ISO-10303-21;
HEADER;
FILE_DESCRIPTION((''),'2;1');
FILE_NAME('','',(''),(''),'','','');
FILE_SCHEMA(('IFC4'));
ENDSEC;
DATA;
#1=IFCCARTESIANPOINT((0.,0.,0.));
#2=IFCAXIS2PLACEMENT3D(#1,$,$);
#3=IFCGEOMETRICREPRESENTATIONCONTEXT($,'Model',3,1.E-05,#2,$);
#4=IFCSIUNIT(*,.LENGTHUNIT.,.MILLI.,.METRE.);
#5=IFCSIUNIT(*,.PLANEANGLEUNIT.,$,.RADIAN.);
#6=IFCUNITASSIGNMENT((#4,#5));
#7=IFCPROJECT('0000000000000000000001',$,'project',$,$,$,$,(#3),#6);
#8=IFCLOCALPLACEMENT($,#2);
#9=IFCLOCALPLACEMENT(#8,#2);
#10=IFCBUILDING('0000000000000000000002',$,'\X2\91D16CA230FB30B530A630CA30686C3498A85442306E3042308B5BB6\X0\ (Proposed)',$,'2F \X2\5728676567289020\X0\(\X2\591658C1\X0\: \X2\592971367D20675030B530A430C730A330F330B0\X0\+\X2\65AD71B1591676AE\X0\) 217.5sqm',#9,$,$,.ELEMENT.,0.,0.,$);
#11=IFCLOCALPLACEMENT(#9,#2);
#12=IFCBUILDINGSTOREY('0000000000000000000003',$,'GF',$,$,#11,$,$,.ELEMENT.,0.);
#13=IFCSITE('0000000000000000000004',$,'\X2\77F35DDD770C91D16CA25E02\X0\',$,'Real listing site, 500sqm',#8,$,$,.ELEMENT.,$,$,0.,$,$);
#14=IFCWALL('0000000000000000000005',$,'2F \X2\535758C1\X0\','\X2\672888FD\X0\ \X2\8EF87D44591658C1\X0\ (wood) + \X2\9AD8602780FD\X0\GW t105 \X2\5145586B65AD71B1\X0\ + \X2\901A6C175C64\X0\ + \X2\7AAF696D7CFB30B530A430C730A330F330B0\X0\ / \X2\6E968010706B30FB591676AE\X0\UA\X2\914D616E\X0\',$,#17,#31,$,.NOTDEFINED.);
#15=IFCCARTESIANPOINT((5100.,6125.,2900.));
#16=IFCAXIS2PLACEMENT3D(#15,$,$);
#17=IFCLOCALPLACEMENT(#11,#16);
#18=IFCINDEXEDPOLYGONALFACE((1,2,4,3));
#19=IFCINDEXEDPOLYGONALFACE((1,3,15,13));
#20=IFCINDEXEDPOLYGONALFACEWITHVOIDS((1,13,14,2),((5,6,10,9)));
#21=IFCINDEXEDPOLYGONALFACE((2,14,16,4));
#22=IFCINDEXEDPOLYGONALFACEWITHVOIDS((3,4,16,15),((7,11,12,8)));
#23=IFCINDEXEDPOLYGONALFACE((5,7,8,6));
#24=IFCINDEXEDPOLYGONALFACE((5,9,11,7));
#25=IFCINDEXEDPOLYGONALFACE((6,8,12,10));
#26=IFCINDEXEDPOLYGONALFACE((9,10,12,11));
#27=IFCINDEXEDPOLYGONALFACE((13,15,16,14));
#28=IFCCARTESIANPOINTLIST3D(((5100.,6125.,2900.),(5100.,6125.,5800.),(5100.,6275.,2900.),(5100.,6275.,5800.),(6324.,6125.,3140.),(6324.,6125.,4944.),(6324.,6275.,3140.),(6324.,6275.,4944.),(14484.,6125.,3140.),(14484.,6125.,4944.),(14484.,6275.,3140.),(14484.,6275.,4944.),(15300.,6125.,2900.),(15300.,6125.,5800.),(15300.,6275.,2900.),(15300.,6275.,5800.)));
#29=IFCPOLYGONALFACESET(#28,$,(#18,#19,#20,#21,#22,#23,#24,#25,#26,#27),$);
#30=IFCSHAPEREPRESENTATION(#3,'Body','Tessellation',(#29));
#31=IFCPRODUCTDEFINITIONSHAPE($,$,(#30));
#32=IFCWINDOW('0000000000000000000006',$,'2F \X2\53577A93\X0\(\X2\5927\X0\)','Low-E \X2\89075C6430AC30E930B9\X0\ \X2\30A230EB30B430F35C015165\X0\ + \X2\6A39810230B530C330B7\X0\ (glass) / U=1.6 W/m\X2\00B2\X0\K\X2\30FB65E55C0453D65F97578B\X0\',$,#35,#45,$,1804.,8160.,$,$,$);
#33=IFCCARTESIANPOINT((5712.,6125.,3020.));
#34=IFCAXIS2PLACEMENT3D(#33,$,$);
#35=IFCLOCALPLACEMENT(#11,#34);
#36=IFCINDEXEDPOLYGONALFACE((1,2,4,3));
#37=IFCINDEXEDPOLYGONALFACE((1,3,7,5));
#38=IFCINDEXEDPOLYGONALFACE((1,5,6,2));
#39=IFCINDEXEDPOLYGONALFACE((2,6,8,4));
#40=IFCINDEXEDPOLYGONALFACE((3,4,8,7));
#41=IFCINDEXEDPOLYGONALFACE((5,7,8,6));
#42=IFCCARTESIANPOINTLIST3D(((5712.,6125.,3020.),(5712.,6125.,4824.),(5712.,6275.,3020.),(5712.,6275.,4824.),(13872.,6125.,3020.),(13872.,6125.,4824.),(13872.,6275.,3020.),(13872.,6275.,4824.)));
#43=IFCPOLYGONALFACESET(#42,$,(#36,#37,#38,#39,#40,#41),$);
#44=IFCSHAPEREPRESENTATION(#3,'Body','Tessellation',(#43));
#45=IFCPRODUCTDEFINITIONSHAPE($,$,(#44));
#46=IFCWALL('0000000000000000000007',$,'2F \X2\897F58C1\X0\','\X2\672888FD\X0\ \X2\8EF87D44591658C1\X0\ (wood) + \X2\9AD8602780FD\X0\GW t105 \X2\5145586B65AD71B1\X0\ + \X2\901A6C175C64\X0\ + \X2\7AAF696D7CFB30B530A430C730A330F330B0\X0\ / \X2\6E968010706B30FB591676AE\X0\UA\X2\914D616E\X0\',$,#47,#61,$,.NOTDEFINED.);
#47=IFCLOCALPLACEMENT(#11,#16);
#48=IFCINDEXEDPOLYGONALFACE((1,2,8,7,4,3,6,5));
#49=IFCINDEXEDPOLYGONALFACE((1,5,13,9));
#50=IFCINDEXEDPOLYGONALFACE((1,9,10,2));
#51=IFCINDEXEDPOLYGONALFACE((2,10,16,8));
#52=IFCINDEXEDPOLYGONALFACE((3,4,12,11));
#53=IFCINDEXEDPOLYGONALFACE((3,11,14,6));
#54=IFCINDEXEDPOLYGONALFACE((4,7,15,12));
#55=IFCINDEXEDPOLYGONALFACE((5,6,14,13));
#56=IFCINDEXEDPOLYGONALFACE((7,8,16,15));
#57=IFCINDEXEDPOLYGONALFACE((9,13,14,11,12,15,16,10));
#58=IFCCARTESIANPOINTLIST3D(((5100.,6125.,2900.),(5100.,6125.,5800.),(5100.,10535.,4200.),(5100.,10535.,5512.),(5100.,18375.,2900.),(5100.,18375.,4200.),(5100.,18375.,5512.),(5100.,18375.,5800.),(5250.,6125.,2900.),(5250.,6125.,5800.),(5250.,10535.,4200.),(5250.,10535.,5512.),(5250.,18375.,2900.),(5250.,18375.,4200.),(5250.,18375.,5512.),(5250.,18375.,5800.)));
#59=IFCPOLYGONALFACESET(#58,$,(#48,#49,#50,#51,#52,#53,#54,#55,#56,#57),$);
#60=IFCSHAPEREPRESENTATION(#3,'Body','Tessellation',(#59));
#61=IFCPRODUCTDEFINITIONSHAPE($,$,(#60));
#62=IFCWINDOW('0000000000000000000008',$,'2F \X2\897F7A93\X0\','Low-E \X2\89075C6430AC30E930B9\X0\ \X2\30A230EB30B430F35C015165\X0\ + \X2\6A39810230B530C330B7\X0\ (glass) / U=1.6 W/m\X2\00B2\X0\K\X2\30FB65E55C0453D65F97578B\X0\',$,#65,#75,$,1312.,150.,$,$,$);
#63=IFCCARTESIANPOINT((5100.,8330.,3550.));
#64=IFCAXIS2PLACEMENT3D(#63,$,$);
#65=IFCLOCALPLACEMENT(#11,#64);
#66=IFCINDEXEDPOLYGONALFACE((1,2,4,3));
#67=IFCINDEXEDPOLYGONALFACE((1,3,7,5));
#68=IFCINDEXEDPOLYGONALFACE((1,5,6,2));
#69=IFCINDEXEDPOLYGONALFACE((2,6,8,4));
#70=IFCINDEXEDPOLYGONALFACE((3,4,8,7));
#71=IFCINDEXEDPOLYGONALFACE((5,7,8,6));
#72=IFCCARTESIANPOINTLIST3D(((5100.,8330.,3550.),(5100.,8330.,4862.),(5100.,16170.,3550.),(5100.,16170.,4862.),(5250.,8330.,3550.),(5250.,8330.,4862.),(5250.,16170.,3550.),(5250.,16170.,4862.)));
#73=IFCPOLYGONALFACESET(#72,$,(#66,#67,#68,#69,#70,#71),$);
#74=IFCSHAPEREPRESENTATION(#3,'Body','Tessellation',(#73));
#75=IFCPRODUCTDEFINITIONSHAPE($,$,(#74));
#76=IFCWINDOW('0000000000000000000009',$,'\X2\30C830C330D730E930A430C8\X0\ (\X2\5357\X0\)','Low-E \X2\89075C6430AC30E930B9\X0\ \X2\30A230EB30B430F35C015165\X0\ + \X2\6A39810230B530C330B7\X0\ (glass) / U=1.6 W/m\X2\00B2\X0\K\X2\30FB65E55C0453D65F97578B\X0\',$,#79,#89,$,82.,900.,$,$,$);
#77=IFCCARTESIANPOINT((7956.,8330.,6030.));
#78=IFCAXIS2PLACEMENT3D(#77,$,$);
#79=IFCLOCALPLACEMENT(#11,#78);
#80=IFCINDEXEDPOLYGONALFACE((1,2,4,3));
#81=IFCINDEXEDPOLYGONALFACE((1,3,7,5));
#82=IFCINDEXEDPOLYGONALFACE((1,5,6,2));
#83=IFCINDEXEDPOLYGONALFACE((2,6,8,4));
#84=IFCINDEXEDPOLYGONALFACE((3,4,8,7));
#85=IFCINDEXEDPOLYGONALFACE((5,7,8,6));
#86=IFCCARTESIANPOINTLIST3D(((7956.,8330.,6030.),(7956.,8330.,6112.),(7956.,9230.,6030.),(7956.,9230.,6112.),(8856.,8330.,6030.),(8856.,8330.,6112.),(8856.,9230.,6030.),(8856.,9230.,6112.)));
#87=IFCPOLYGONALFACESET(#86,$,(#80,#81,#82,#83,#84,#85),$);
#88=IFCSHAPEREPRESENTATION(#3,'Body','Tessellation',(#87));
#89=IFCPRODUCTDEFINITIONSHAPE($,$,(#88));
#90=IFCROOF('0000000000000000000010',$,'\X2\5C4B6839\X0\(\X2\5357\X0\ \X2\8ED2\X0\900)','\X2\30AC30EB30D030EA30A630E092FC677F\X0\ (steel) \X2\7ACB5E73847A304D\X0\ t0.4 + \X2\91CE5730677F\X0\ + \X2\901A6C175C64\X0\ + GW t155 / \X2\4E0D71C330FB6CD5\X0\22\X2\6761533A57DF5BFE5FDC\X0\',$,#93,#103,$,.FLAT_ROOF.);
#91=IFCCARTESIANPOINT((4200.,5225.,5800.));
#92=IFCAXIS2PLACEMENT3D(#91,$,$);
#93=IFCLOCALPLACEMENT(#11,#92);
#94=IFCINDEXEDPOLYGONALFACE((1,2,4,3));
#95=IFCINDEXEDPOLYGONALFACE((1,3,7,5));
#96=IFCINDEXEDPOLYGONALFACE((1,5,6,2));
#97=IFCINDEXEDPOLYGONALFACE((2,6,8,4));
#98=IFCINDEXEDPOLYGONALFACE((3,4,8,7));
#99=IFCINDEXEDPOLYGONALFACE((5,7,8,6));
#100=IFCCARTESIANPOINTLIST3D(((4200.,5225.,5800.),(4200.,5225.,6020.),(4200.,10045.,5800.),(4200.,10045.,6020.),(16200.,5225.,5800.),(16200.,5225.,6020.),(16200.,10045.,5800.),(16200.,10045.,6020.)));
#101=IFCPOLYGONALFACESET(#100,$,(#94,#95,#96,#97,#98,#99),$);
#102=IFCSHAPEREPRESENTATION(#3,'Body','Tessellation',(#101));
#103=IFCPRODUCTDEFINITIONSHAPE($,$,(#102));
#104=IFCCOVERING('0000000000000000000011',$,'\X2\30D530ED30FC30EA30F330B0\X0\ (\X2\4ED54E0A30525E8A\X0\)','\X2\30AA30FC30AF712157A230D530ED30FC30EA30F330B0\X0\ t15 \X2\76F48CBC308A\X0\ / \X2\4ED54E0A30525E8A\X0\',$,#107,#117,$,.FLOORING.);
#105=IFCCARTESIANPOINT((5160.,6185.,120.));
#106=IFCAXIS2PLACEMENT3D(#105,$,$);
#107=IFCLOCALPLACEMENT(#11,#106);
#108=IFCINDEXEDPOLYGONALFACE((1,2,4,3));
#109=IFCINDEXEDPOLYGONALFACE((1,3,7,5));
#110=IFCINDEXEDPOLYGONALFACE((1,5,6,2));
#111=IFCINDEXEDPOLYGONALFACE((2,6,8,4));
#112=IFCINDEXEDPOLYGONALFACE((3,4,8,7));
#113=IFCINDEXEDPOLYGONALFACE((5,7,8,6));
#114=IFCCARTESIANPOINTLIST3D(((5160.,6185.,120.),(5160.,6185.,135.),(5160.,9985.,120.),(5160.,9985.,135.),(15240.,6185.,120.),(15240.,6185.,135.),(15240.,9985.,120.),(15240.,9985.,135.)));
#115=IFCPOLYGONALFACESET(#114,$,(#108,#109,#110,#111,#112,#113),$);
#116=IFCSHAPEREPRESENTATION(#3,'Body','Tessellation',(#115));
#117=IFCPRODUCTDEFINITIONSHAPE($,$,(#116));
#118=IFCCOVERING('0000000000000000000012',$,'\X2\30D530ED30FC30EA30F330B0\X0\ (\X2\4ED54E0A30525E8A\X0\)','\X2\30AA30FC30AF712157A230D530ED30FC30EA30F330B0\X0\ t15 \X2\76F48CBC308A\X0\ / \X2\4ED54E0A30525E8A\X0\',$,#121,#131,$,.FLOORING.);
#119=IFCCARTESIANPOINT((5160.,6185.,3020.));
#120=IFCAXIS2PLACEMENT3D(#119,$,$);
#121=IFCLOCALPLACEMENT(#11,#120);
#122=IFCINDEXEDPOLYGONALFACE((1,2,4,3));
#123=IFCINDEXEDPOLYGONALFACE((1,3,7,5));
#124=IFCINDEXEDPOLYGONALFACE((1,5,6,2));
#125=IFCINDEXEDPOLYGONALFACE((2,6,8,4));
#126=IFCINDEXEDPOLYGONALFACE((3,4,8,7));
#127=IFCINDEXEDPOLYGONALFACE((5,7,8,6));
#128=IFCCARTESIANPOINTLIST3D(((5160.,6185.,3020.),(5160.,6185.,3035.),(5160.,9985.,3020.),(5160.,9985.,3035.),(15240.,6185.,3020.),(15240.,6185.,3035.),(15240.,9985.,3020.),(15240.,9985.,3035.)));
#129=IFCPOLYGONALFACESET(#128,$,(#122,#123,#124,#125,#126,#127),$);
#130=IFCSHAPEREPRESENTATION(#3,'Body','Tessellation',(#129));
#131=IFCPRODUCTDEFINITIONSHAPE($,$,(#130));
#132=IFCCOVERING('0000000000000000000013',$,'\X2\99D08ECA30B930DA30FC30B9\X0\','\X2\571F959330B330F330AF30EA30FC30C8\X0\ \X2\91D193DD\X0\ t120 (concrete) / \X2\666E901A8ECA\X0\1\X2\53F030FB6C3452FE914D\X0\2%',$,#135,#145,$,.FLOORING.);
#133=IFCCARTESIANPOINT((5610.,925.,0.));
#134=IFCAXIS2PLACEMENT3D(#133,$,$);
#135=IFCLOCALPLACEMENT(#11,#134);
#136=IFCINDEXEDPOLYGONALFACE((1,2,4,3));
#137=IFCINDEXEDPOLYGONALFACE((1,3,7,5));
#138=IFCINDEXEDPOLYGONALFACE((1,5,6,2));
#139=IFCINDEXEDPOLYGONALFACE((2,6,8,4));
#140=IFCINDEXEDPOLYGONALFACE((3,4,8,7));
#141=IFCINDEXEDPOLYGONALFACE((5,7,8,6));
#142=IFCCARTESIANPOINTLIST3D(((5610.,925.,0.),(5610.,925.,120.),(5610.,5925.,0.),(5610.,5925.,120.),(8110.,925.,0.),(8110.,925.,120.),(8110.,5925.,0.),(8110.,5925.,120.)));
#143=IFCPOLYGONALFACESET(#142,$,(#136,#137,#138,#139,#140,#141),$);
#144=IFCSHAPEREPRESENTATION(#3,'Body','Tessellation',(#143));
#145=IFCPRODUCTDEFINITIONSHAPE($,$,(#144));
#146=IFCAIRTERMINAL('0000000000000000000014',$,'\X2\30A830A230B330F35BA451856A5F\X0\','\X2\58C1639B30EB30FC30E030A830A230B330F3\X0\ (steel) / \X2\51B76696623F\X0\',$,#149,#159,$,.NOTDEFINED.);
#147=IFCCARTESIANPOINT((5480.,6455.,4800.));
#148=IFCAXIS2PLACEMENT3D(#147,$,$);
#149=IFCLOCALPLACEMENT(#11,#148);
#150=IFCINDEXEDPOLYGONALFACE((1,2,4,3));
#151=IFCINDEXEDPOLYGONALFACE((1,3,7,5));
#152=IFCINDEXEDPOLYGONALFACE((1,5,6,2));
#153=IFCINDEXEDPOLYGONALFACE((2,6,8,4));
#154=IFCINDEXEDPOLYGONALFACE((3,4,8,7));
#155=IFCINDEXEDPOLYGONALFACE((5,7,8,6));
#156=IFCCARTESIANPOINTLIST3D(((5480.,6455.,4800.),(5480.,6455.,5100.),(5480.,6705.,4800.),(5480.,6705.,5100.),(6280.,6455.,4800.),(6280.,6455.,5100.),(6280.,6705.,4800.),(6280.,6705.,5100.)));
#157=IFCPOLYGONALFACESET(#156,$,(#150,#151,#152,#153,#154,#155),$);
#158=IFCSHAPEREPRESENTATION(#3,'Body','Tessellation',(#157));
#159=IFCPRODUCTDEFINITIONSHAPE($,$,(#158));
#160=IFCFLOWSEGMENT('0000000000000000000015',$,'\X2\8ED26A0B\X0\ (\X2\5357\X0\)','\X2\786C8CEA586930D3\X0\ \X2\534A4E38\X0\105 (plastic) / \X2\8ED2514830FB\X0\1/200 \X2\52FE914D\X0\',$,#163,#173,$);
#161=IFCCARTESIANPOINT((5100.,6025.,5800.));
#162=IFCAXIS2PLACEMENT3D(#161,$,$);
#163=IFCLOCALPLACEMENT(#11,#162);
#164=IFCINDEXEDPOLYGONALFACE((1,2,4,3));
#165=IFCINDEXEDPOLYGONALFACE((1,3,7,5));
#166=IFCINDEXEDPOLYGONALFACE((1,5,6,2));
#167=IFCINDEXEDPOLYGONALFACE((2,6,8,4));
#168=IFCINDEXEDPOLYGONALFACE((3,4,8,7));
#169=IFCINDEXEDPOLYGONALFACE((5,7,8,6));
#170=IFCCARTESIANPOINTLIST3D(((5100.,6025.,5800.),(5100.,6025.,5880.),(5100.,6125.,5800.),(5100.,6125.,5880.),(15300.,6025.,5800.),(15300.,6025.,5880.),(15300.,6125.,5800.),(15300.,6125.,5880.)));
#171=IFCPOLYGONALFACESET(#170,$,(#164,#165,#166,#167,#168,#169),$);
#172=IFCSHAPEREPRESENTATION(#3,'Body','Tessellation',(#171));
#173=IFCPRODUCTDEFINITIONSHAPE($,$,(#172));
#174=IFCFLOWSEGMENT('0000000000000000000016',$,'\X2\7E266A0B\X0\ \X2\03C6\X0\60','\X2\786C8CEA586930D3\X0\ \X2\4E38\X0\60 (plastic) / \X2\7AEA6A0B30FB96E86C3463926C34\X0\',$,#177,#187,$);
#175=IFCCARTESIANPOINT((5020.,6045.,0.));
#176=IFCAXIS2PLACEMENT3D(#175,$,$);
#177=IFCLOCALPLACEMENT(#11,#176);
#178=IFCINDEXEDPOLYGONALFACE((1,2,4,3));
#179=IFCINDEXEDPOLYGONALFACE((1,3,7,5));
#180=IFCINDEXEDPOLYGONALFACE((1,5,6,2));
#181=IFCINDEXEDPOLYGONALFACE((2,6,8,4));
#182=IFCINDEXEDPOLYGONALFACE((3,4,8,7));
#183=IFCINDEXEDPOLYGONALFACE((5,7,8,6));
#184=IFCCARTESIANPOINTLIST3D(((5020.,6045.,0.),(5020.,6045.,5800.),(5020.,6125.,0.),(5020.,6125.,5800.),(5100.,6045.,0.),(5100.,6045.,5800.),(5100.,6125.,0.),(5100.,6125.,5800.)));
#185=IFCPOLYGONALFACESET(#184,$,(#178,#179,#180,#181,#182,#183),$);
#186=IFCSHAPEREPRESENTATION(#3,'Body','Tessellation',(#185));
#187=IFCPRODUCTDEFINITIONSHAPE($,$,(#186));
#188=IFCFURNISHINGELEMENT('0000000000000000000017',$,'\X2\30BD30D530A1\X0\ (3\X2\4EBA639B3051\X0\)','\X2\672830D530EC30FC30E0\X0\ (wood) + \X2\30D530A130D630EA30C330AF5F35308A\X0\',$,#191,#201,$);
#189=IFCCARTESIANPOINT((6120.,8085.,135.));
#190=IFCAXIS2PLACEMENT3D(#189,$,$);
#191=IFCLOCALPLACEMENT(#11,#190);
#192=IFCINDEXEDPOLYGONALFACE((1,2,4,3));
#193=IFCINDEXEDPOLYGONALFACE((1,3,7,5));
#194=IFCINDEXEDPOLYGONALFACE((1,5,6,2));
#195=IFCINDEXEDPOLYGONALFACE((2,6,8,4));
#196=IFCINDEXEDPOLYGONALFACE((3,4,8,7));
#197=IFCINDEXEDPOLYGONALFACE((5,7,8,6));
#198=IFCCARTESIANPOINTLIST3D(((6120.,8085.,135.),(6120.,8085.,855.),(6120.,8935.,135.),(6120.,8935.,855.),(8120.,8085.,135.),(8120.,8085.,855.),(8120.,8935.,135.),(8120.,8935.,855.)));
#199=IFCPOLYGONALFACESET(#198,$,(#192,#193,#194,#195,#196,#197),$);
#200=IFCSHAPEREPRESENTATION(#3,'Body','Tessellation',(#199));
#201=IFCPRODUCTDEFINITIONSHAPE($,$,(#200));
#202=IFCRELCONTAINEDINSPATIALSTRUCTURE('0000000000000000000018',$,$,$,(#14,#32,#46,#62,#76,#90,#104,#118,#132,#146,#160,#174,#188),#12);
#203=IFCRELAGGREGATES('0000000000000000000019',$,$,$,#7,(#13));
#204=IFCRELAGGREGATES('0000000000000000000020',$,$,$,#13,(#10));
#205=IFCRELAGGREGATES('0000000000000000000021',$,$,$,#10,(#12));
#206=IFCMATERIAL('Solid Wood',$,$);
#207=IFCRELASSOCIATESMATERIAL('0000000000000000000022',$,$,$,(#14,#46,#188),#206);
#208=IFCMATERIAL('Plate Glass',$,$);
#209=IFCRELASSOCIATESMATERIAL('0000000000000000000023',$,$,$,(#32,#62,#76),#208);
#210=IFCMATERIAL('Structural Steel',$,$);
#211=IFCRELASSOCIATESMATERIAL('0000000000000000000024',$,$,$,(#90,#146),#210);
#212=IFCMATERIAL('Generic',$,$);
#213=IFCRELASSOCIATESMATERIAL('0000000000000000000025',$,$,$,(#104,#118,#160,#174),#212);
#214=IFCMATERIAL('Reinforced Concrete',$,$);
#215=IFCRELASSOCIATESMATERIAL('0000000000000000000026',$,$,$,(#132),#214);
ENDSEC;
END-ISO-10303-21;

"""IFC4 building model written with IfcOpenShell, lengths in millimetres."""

from ifc_helpers import new_model, si_unit, frame, frame_2d, origin, place, context, project, spatial, rectangle, extrude, material, element, fill, save


model = new_model("IFC4")

# Units and contexts
model_context = context("Model", 3, precision=1e-05, world=origin())
ifc_project = project(units=[si_unit("LENGTHUNIT", "METRE", prefix="MILLI"), si_unit("PLANEANGLEUNIT", "RADIAN")], contexts=[model_context])

# Site, building, storey
site_placement = place(None, origin())
site = spatial("IfcSite", under=ifc_project, at=site_placement, Name="石川県金沢市", ObjectType="Real listing site, 500sqm", CompositionType="ELEMENT", RefElevation=0.0)
building_placement = place(site_placement, origin())
building = spatial("IfcBuilding", under=site, at=building_placement, Name="金沢・サウナと水風呂のある家 (Proposed)", ObjectType="2F 在来木造(外壁: 天然素材サイディング+断熱外皮) 217.5sqm", CompositionType="ELEMENT", ElevationOfRefHeight=0.0, ElevationOfTerrain=0.0)
storey_placement = place(building_placement, origin())
storey = spatial("IfcBuildingStorey", under=building, at=storey_placement, Name="GF", CompositionType="ELEMENT", Elevation=0.0)

# Shared definitions
ifc_material_1 = material(Name="Solid Wood")

# Shared definitions
ifc_material_2 = material(Name="Reinforced Concrete")

# Shared definitions
ifc_material_3 = material(Name="Plate Glass")

# Walls, openings, windows
wall_1_placement = place(storey_placement, frame((5100.0, 6125.0, 2900.0)))
wall_1 = element("IfcWall", 1, at=wall_1_placement, inside=storey, material=ifc_material_1, Name="2F 南壁", Description="木製 軸組外壁 (wood) + 高性能GW t105 充填断熱 + 通気層 + 窯業系サイディング / 準耐火・外皮UA配慮", PredefinedType="NOTDEFINED", context=model_context, shape_type="SweptSolid", body=[
    extrude(rectangle(XDim=10200.0, YDim=150.0, at=frame_2d((5100.0, 75.0))), frame((5100.0, 6125.0, 2900.0)), (0.0, 0.0, 1.0), 2900.0),
])
opening_1_placement = place(storey_placement, frame((5712.0, 6125.0, 3020.0)))
opening_1 = element("IfcOpeningElement", 2, at=opening_1_placement, cuts=wall_1, PredefinedType="NOTDEFINED", context=model_context, shape_type="SweptSolid", body=[
    extrude(rectangle(XDim=8160.0, YDim=150.0, at=frame_2d((4080.0, 75.0))), frame((5712.0, 6125.0, 3020.0)), (0.0, 0.0, 1.0), 1804.0),
])
window_1_placement = place(storey_placement, frame((5712.0, 6125.0, 3020.0)))
window_1 = element("IfcWindow", 3, at=window_1_placement, inside=storey, material=ifc_material_3, Name="2F 南窓(大)", Description="Low-E 複層ガラス アルゴン封入 + 樹脂サッシ (glass) / U=1.6 W/m²K・日射取得型", OverallHeight=1804.0, OverallWidth=8160.0, context=model_context, shape_type="SweptSolid", body=[
    extrude(rectangle(XDim=8160.0, YDim=150.0, at=frame_2d((4080.0, 75.0))), frame((5712.0, 6125.0, 3020.0)), (0.0, 0.0, 1.0), 1804.0),
])
fill(opening_1, window_1)
wall_2_placement = place(storey_placement, frame((5100.0, 6125.0, 2900.0)))
wall_2 = element("IfcWall", 4, at=wall_2_placement, inside=storey, material=ifc_material_1, Name="2F 西壁", Description="木製 軸組外壁 (wood) + 高性能GW t105 充填断熱 + 通気層 + 窯業系サイディング / 準耐火・外皮UA配慮", PredefinedType="NOTDEFINED", context=model_context, shape_type="SweptSolid", body=[
    extrude(rectangle(XDim=150.0, YDim=12250.0, at=frame_2d((75.0, 6125.0))), frame((5100.0, 6125.0, 2900.0)), (0.0, 0.0, 1.0), 2900.0),
])
opening_2_placement = place(storey_placement, frame((5100.0, 8330.0, 3550.0)))
opening_2 = element("IfcOpeningElement", 5, at=opening_2_placement, cuts=wall_2, PredefinedType="NOTDEFINED", context=model_context, shape_type="SweptSolid", body=[
    extrude(rectangle(XDim=150.0, YDim=7840.0, at=frame_2d((75.0, 3920.0))), frame((5100.0, 8330.0, 3550.0)), (0.0, 0.0, 1.0), 1312.0),
])
window_2_placement = place(storey_placement, frame((5100.0, 8330.0, 3550.0)))
window_2 = element("IfcWindow", 6, at=window_2_placement, inside=storey, material=ifc_material_3, Name="2F 西窓", Description="Low-E 複層ガラス アルゴン封入 + 樹脂サッシ (glass) / U=1.6 W/m²K・日射取得型", OverallHeight=1312.0, OverallWidth=150.0, context=model_context, shape_type="SweptSolid", body=[
    extrude(rectangle(XDim=150.0, YDim=7840.0, at=frame_2d((75.0, 3920.0))), frame((5100.0, 8330.0, 3550.0)), (0.0, 0.0, 1.0), 1312.0),
])
fill(opening_2, window_2)

# Window
window_3_placement = place(storey_placement, frame((7956.0, 8330.0, 6030.0)))
element("IfcWindow", 7, at=window_3_placement, inside=storey, material=ifc_material_3, Name="トップライト (南)", Description="Low-E 複層ガラス アルゴン封入 + 樹脂サッシ (glass) / U=1.6 W/m²K・日射取得型", OverallHeight=82.0, OverallWidth=900.0, context=model_context, shape_type="SweptSolid", body=[
    extrude(rectangle(XDim=900.0, YDim=900.0, at=frame_2d((450.0, 450.0))), frame((7956.0, 8330.0, 6030.0)), (0.0, 0.0, 1.0), 82.0),
])

# Roof
ifc_material_4 = material(Name="Structural Steel")
for number, where, name in (
    (8, (4200.0, 5225.0, 5800.0), "屋根(南 軒900)"),
):
    element("IfcRoof", number, at=place(storey_placement, frame(where)), inside=storey, material=ifc_material_4, Name=name, Description="ガルバリウム鋼板 (steel) 立平葺き t0.4 + 野地板 + 通気層 + GW t155 / 不燃・法22条区域対応", PredefinedType="FLAT_ROOF", context=model_context, shape_type="SweptSolid", body=[
        extrude(rectangle(XDim=12000.0, YDim=4820.0, at=frame_2d((6000.0, 2410.0))), frame((4200.0, 5225.0, 5800.0)), (0.0, 0.0, 1.0), 220.0),
    ])

# Coverings
ifc_material_5 = material(Name="Generic")
covering_1_placement = place(storey_placement, frame((5160.0, 6185.0, 120.0)))
element("IfcCovering", 9, at=covering_1_placement, inside=storey, material=ifc_material_5, Name="フローリング (仕上げ床)", Description="オーク無垢フローリング t15 直貼り / 仕上げ床", PredefinedType="FLOORING", context=model_context, shape_type="SweptSolid", body=[
    extrude(rectangle(XDim=10080.0, YDim=3800.0, at=frame_2d((5040.0, 1900.0))), frame((5160.0, 6185.0, 120.0)), (0.0, 0.0, 1.0), 15.0),
])
covering_2_placement = place(storey_placement, frame((5160.0, 6185.0, 3020.0)))
element("IfcCovering", 10, at=covering_2_placement, inside=storey, material=ifc_material_5, Name="フローリング (仕上げ床)", Description="オーク無垢フローリング t15 直貼り / 仕上げ床", PredefinedType="FLOORING", context=model_context, shape_type="SweptSolid", body=[
    extrude(rectangle(XDim=10080.0, YDim=3800.0, at=frame_2d((5040.0, 1900.0))), frame((5160.0, 6185.0, 3020.0)), (0.0, 0.0, 1.0), 15.0),
])
covering_3_placement = place(storey_placement, frame((5610.0, 925.0, 0.0)))
element("IfcCovering", 11, at=covering_3_placement, inside=storey, material=ifc_material_2, Name="駐車スペース", Description="土間コンクリート 金鏝 t120 (concrete) / 普通車1台・水勾配2%", PredefinedType="FLOORING", context=model_context, shape_type="SweptSolid", body=[
    extrude(rectangle(XDim=2500.0, YDim=5000.0, at=frame_2d((1250.0, 2500.0))), frame((5610.0, 925.0, 0.0)), (0.0, 0.0, 1.0), 120.0),
])

# Air terminal
air_terminal_placement = place(storey_placement, frame((5480.0, 6455.0, 4800.0)))
element("IfcAirTerminal", 12, at=air_terminal_placement, inside=storey, material=ifc_material_4, Name="エアコン室内機", Description="壁掛ルームエアコン (steel) / 冷暖房", PredefinedType="NOTDEFINED", context=model_context, shape_type="SweptSolid", body=[
    extrude(rectangle(XDim=800.0, YDim=250.0, at=frame_2d((400.0, 125.0))), frame((5480.0, 6455.0, 4800.0)), (0.0, 0.0, 1.0), 300.0),
])

# Flow segments
flow_segment_1_placement = place(storey_placement, frame((5100.0, 6025.0, 5800.0)))
element("IfcFlowSegment", 13, at=flow_segment_1_placement, inside=storey, material=ifc_material_5, Name="軒樋 (南)", Description="硬質塩ビ 半丸105 (plastic) / 軒先・1/200 勾配", context=model_context, shape_type="SweptSolid", body=[
    extrude(rectangle(XDim=10200.0, YDim=100.0, at=frame_2d((5100.0, 50.0))), frame((5100.0, 6025.0, 5800.0)), (0.0, 0.0, 1.0), 80.0),
])
flow_segment_2_placement = place(storey_placement, frame((5020.0, 6045.0, 0.0)))
element("IfcFlowSegment", 14, at=flow_segment_2_placement, inside=storey, material=ifc_material_5, Name="縦樋 φ60", Description="硬質塩ビ 丸60 (plastic) / 竪樋・雨水排水", context=model_context, shape_type="SweptSolid", body=[
    extrude(rectangle(XDim=80.0, YDim=80.0, at=frame_2d((40.0, 40.0))), frame((5020.0, 6045.0, 0.0)), (0.0, 0.0, 1.0), 5800.0),
])

# Furnishing element
furnishing_1_placement = place(storey_placement, frame((6120.0, 8085.0, 135.0)))
element("IfcFurnishingElement", 15, at=furnishing_1_placement, inside=storey, material=ifc_material_1, Name="ソファ (3人掛け)", Description="木フレーム (wood) + ファブリック張り", context=model_context, shape_type="SweptSolid", body=[
    extrude(rectangle(XDim=2000.0, YDim=850.0, at=frame_2d((1000.0, 425.0))), frame((6120.0, 8085.0, 135.0)), (0.0, 0.0, 1.0), 720.0),
])

save(model, "model.ifc")
